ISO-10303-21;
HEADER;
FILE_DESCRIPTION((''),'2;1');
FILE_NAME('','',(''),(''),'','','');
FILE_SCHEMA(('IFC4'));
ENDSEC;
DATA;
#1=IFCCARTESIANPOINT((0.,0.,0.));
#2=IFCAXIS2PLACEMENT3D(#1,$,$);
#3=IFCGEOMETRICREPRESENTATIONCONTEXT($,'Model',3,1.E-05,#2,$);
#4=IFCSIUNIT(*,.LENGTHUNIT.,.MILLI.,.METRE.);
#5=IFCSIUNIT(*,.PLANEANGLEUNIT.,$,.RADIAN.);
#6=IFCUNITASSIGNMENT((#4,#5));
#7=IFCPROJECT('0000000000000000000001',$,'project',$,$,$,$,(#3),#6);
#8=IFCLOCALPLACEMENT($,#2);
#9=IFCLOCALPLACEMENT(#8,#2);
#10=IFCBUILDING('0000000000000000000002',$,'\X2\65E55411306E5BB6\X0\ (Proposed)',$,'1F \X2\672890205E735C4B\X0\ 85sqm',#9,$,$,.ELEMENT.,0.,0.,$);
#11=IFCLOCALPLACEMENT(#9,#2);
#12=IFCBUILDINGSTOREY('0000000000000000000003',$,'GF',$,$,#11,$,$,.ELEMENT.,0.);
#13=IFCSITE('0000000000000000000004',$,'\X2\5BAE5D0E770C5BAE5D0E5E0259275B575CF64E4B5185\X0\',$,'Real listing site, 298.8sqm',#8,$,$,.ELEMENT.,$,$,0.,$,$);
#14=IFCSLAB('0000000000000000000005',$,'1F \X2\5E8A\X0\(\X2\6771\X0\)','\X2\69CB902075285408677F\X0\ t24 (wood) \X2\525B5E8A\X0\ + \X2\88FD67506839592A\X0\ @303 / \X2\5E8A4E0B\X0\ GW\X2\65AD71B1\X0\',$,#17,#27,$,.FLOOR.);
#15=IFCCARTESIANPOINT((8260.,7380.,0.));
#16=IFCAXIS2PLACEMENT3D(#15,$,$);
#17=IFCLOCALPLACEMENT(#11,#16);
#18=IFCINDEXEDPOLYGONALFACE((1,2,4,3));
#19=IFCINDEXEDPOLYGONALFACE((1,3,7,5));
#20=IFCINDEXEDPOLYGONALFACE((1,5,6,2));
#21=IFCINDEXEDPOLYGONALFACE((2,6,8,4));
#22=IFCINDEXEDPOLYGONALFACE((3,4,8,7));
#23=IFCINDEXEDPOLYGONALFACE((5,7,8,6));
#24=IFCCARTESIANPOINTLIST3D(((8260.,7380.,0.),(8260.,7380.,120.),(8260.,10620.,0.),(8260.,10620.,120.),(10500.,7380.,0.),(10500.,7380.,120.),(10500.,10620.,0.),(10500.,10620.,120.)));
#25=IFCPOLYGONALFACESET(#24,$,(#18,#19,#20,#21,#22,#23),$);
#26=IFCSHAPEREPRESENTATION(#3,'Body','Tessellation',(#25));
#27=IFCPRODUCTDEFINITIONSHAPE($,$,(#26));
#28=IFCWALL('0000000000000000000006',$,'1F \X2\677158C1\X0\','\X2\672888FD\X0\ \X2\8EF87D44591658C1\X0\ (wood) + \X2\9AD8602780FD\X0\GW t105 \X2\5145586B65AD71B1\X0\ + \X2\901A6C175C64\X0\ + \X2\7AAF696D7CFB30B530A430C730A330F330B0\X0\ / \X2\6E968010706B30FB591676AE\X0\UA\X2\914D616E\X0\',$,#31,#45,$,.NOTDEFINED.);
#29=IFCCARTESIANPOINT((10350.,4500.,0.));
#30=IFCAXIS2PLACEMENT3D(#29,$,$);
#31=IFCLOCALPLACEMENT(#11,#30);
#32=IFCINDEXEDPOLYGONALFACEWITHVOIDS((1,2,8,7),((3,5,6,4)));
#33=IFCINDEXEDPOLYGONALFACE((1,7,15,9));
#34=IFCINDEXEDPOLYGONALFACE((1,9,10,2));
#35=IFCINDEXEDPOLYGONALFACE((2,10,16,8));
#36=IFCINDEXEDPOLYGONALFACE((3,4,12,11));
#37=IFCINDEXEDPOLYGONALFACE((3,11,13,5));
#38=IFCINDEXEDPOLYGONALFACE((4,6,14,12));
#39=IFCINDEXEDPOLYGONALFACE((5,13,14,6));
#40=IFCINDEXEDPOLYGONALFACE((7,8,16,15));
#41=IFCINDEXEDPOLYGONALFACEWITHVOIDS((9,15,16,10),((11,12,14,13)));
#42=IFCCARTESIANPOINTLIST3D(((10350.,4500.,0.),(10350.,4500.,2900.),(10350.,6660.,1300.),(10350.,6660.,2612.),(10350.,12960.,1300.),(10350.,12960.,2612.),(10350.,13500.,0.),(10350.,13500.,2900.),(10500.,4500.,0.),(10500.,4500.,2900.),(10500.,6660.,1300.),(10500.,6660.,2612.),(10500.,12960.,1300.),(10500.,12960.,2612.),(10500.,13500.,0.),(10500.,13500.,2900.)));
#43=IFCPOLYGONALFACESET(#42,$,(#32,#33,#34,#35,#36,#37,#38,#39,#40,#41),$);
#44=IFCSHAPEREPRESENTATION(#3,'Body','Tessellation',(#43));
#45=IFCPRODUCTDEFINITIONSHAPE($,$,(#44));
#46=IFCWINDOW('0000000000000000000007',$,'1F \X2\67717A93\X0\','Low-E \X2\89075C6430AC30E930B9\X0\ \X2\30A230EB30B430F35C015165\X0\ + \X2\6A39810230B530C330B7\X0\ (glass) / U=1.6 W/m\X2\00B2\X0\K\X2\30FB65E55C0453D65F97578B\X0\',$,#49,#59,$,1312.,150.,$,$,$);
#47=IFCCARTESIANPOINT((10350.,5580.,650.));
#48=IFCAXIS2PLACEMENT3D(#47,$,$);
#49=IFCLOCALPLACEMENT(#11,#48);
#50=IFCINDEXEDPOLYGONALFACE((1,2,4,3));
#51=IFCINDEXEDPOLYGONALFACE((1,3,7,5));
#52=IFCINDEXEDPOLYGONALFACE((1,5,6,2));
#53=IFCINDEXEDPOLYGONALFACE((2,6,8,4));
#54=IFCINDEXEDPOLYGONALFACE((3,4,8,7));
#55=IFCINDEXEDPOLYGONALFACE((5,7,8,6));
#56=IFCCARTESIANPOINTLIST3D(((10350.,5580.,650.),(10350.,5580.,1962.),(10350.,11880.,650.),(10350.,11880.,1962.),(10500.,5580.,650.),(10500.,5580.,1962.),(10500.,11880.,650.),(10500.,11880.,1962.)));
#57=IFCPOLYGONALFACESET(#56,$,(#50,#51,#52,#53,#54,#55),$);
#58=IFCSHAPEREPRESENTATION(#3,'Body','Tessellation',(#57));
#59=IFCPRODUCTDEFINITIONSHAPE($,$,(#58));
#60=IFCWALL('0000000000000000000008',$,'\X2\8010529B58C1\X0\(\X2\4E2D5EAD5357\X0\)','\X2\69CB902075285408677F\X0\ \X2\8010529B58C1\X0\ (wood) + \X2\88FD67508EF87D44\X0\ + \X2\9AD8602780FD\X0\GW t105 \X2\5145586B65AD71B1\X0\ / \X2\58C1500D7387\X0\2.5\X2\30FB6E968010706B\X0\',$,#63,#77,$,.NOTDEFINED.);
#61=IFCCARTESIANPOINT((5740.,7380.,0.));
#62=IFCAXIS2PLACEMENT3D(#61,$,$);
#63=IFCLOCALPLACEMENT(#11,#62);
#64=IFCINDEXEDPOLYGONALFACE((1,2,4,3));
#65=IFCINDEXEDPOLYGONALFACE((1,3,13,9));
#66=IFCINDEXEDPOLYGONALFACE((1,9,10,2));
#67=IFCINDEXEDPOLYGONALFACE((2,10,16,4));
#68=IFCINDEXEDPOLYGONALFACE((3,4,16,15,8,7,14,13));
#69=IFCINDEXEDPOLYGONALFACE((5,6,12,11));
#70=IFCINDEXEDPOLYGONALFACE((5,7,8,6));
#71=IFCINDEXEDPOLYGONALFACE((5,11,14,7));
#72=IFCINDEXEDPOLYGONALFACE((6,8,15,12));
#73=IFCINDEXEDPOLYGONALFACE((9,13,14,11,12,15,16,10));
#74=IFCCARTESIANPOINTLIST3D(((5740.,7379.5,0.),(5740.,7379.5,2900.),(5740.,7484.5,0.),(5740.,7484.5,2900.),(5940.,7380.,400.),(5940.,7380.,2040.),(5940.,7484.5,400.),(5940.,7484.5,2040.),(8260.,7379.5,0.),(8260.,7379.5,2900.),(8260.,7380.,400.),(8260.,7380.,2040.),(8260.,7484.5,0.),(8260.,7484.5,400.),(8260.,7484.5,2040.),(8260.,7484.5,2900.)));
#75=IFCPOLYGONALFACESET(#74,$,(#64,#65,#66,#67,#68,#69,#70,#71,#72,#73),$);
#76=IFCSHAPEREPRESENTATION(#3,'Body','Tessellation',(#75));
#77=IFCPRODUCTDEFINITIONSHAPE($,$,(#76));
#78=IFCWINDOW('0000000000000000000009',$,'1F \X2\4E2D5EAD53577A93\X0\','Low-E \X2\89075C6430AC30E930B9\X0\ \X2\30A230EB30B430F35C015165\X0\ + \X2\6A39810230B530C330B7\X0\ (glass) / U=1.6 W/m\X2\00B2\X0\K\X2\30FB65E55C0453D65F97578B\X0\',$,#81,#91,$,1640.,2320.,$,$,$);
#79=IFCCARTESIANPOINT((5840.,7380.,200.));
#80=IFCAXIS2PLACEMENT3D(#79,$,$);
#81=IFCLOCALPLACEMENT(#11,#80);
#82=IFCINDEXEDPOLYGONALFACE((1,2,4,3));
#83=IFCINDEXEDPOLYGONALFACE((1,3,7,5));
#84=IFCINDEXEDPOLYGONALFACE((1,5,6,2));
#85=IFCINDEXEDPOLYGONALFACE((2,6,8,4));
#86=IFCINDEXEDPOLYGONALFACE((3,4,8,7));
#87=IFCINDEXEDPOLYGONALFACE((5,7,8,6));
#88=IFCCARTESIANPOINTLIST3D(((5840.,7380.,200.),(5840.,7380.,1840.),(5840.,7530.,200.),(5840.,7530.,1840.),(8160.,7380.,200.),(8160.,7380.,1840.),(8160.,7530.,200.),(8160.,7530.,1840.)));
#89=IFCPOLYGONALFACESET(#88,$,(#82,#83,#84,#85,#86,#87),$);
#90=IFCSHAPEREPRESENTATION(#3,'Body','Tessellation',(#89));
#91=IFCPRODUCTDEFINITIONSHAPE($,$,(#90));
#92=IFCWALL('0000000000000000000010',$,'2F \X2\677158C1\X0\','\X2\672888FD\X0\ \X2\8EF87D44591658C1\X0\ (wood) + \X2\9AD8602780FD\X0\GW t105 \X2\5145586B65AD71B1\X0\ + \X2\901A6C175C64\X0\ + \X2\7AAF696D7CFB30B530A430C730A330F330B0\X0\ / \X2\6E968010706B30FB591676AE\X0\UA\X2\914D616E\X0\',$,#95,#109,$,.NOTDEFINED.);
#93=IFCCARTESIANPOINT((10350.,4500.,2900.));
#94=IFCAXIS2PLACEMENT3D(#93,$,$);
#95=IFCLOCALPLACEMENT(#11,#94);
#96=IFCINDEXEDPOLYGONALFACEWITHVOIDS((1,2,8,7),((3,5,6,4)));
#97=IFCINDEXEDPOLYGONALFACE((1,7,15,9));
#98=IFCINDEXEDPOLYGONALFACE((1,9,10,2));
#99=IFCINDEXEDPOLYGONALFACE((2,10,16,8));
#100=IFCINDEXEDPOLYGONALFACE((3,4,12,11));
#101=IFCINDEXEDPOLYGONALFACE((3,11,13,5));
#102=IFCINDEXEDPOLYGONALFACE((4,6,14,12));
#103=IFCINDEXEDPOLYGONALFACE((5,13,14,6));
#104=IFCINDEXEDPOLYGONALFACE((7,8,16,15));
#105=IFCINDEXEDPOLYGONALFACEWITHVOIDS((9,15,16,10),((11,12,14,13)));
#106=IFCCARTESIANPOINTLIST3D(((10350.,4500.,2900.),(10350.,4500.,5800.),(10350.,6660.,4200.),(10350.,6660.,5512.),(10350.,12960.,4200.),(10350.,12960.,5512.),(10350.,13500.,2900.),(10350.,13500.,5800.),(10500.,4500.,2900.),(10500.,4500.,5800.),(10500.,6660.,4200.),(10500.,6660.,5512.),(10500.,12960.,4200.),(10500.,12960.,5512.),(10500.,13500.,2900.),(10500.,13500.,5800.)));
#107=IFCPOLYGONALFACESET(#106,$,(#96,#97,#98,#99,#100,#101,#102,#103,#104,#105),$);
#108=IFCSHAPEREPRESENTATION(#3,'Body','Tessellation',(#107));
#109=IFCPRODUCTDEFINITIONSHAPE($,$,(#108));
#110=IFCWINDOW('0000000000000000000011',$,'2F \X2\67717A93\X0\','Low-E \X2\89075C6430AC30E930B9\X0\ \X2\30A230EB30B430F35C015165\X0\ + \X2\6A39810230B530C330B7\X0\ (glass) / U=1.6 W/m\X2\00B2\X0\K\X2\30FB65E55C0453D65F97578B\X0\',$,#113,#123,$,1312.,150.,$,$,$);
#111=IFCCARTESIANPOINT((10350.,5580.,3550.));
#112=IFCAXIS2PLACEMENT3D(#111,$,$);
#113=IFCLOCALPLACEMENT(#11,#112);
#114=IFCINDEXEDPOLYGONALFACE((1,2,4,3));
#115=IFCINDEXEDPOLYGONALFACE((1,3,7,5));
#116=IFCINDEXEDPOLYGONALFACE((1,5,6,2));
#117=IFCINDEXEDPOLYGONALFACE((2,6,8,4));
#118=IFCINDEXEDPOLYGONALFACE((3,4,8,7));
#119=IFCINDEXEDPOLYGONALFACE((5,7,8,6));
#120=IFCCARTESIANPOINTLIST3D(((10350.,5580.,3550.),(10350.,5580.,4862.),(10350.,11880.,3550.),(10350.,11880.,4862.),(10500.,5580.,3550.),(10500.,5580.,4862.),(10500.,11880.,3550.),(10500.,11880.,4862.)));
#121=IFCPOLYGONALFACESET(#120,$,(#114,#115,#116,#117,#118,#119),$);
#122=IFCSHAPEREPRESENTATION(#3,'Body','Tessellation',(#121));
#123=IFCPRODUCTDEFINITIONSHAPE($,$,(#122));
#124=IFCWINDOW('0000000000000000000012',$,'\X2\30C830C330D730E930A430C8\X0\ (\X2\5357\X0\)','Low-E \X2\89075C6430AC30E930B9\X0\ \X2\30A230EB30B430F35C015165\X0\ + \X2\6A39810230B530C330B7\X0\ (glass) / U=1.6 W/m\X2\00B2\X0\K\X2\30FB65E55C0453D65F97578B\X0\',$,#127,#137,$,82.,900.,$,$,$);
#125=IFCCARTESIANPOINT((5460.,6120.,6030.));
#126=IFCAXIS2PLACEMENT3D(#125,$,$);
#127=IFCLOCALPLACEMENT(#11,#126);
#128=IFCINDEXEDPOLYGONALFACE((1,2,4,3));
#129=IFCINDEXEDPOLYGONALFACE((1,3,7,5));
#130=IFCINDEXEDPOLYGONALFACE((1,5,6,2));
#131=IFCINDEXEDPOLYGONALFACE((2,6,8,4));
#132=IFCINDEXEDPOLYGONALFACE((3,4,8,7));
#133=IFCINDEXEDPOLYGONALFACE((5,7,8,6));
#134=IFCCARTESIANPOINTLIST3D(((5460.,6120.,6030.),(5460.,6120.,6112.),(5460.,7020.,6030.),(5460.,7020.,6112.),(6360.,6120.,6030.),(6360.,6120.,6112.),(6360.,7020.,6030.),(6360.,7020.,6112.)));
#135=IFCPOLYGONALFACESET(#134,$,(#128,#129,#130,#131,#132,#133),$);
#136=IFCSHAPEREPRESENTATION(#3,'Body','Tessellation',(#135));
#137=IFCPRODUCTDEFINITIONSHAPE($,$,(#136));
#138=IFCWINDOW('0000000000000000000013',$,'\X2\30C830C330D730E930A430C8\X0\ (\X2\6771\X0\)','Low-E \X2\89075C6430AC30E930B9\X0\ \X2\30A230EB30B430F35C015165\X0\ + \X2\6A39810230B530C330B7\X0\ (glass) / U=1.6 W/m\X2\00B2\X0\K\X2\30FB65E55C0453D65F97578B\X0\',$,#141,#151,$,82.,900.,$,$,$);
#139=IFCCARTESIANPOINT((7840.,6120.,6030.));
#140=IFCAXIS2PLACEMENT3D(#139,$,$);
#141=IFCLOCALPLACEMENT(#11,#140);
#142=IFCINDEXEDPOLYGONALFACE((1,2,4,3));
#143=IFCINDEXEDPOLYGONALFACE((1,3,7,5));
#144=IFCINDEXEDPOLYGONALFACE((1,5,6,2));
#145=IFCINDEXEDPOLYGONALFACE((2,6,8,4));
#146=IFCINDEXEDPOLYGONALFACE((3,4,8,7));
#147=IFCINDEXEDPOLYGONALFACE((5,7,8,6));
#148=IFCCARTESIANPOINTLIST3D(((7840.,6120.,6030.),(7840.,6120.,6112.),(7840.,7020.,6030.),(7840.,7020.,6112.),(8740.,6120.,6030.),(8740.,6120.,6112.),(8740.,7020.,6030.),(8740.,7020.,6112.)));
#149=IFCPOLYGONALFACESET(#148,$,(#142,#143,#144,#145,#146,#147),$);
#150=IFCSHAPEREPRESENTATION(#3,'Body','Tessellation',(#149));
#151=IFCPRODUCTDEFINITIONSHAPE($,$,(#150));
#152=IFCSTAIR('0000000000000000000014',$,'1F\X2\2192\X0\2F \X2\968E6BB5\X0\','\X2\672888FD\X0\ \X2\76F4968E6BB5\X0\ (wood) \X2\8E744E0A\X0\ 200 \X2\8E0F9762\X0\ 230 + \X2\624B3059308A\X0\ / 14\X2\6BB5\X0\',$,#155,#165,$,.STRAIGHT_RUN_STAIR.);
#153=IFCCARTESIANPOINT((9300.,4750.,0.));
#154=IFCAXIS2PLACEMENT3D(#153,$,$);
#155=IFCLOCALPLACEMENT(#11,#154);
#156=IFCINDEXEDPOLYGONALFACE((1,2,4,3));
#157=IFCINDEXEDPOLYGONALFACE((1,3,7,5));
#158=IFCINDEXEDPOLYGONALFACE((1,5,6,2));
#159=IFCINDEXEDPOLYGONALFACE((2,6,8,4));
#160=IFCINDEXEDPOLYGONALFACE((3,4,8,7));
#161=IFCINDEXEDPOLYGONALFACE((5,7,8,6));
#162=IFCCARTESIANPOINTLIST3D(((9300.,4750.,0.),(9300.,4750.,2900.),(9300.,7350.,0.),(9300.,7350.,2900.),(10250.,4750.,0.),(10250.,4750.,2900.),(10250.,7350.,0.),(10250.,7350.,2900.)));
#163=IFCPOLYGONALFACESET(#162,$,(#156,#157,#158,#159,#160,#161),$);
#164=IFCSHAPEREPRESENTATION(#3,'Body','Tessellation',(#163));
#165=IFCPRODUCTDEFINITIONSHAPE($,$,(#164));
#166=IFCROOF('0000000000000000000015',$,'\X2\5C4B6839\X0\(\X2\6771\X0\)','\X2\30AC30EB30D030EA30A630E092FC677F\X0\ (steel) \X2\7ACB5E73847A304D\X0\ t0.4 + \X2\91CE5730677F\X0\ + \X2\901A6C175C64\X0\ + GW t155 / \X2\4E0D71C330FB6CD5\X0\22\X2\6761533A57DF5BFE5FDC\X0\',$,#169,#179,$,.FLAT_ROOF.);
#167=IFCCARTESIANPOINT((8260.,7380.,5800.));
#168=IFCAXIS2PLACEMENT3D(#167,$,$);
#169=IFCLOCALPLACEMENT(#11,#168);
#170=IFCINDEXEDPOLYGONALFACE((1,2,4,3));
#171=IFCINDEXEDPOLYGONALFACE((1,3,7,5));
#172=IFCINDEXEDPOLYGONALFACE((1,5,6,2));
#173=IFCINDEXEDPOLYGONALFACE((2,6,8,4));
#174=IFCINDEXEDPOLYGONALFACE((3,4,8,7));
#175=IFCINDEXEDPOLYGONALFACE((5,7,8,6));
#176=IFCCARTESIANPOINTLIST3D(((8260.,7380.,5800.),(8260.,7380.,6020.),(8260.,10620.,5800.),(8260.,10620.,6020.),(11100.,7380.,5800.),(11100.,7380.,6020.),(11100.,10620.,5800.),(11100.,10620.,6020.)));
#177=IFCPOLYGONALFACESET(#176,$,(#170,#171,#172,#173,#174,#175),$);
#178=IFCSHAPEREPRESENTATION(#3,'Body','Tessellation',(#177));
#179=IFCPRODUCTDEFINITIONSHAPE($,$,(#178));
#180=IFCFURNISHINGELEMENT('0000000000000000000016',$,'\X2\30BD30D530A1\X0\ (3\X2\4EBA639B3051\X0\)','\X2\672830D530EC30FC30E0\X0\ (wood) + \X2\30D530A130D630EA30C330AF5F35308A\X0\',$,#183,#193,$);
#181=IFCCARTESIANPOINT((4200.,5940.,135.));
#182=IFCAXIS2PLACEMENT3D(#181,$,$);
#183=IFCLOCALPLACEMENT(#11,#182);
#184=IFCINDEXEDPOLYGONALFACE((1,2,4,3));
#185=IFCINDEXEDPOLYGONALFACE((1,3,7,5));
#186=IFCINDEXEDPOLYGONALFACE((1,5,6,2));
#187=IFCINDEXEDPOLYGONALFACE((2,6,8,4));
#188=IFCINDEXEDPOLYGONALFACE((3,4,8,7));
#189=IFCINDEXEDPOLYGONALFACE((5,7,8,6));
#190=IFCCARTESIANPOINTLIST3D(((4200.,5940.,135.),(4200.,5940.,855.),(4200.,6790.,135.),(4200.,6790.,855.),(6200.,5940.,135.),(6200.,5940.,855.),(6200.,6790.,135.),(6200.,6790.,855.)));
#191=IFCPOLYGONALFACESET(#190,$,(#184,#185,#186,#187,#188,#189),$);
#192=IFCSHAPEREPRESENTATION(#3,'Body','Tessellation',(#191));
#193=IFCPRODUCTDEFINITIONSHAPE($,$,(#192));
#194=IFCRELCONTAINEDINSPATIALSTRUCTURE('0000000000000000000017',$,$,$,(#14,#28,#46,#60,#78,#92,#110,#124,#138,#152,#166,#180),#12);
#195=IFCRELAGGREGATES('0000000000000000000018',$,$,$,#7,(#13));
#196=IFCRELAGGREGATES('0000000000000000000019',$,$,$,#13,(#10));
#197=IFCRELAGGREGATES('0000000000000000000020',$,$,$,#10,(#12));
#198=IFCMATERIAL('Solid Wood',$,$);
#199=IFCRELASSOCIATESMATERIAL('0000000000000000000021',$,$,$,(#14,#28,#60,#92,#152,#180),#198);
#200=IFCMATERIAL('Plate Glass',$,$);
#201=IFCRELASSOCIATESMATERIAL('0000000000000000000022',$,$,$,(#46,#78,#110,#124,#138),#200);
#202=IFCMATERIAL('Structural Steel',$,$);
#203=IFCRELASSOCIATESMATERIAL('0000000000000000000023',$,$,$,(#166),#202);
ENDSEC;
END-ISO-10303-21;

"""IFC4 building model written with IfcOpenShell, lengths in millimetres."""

from ifc_helpers import new_model, si_unit, frame, frame_2d, origin, place, context, project, spatial, rectangle, extrude, material, element, fill, save


model = new_model("IFC4")

# Units and contexts
model_context = context("Model", 3, precision=1e-05, world=origin())
ifc_project = project(units=[si_unit("LENGTHUNIT", "METRE", prefix="MILLI"), si_unit("PLANEANGLEUNIT", "RADIAN")], contexts=[model_context])

# Site, building, storey
site_placement = place(None, origin())
site = spatial("IfcSite", under=ifc_project, at=site_placement, Name="宮崎県宮崎市大字島之内", ObjectType="Real listing site, 298.8sqm", CompositionType="ELEMENT", RefElevation=0.0)
building_placement = place(site_placement, origin())
building = spatial("IfcBuilding", under=site, at=building_placement, Name="日向の家 (Proposed)", ObjectType="1F 木造平屋 85sqm", CompositionType="ELEMENT", ElevationOfRefHeight=0.0, ElevationOfTerrain=0.0)
storey_placement = place(building_placement, origin())
storey = spatial("IfcBuildingStorey", under=building, at=storey_placement, Name="GF", CompositionType="ELEMENT", Elevation=0.0)

# Slab
ifc_material_1 = material(Name="Solid Wood")
slab_placement = place(storey_placement, frame((8260.0, 7380.0, 0.0)))
element("IfcSlab", 1, at=slab_placement, inside=storey, material=ifc_material_1, Name="1F 床(東)", Description="構造用合板 t24 (wood) 剛床 + 製材根太 @303 / 床下 GW断熱", PredefinedType="FLOOR", context=model_context, shape_type="SweptSolid", body=[
    extrude(rectangle(XDim=2240.0, YDim=3240.0, at=frame_2d((1120.0, 1620.0))), frame((8260.0, 7380.0, 0.0)), (0.0, 0.0, 1.0), 120.0),
])

# Walls, openings, windows
wall_1_placement = place(storey_placement, frame((10350.0, 4500.0, 0.0)))
wall_1 = element("IfcWall", 2, at=wall_1_placement, inside=storey, material=ifc_material_1, Name="1F 東壁", Description="木製 軸組外壁 (wood) + 高性能GW t105 充填断熱 + 通気層 + 窯業系サイディング / 準耐火・外皮UA配慮", PredefinedType="NOTDEFINED", context=model_context, shape_type="SweptSolid", body=[
    extrude(rectangle(XDim=150.0, YDim=9000.0, at=frame_2d((75.0, 4500.0))), frame((10350.0, 4500.0, 0.0)), (0.0, 0.0, 1.0), 2900.0),
])
opening_1_placement = place(storey_placement, frame((10350.0, 5580.0, 650.0)))
opening_1 = element("IfcOpeningElement", 3, at=opening_1_placement, cuts=wall_1, PredefinedType="NOTDEFINED", context=model_context, shape_type="SweptSolid", body=[
    extrude(rectangle(XDim=150.0, YDim=6300.0, at=frame_2d((75.0, 3150.0))), frame((10350.0, 5580.0, 650.0)), (0.0, 0.0, 1.0), 1312.0),
])
ifc_material_2 = material(Name="Plate Glass")
window_1_placement = place(storey_placement, frame((10350.0, 5580.0, 650.0)))
window_1 = element("IfcWindow", 4, at=window_1_placement, inside=storey, material=ifc_material_2, Name="1F 東窓", Description="Low-E 複層ガラス アルゴン封入 + 樹脂サッシ (glass) / U=1.6 W/m²K・日射取得型", OverallHeight=1312.0, OverallWidth=150.0, context=model_context, shape_type="SweptSolid", body=[
    extrude(rectangle(XDim=150.0, YDim=6300.0, at=frame_2d((75.0, 3150.0))), frame((10350.0, 5580.0, 650.0)), (0.0, 0.0, 1.0), 1312.0),
])
fill(opening_1, window_1)
wall_2_placement = place(storey_placement, frame((5740.0, 7380.0, 0.0)))
wall_2 = element("IfcWall", 5, at=wall_2_placement, inside=storey, material=ifc_material_1, Name="耐力壁(中庭南)", Description="構造用合板 耐力壁 (wood) + 製材軸組 + 高性能GW t105 充填断熱 / 壁倍率2.5・準耐火", PredefinedType="NOTDEFINED", context=model_context, shape_type="SweptSolid", body=[
    extrude(rectangle(XDim=2520.0, YDim=105.0, at=frame_2d((1260.0, 52.0))), frame((5740.0, 7380.0, 0.0)), (0.0, 0.0, 1.0), 2900.0),
])
opening_2_placement = place(storey_placement, frame((5840.0, 7380.0, 200.0)))
opening_2 = element("IfcOpeningElement", 6, at=opening_2_placement, cuts=wall_2, PredefinedType="NOTDEFINED", context=model_context, shape_type="SweptSolid", body=[
    extrude(rectangle(XDim=2320.0, YDim=150.0, at=frame_2d((1160.0, 75.0))), frame((5840.0, 7380.0, 200.0)), (0.0, 0.0, 1.0), 1640.0),
])
window_2_placement = place(storey_placement, frame((5840.0, 7380.0, 200.0)))
window_2 = element("IfcWindow", 7, at=window_2_placement, inside=storey, material=ifc_material_2, Name="1F 中庭南窓", Description="Low-E 複層ガラス アルゴン封入 + 樹脂サッシ (glass) / U=1.6 W/m²K・日射取得型", OverallHeight=1640.0, OverallWidth=2320.0, context=model_context, shape_type="SweptSolid", body=[
    extrude(rectangle(XDim=2320.0, YDim=150.0, at=frame_2d((1160.0, 75.0))), frame((5840.0, 7380.0, 200.0)), (0.0, 0.0, 1.0), 1640.0),
])
fill(opening_2, window_2)

# Wall, opening, window
wall_3_placement = place(storey_placement, frame((10350.0, 4500.0, 2900.0)))
wall_3 = element("IfcWall", 8, at=wall_3_placement, inside=storey, material=ifc_material_1, Name="2F 東壁", Description="木製 軸組外壁 (wood) + 高性能GW t105 充填断熱 + 通気層 + 窯業系サイディング / 準耐火・外皮UA配慮", PredefinedType="NOTDEFINED", context=model_context, shape_type="SweptSolid", body=[
    extrude(rectangle(XDim=150.0, YDim=9000.0, at=frame_2d((75.0, 4500.0))), frame((10350.0, 4500.0, 2900.0)), (0.0, 0.0, 1.0), 2900.0),
])
opening_3_placement = place(storey_placement, frame((10350.0, 5580.0, 3550.0)))
opening_3 = element("IfcOpeningElement", 9, at=opening_3_placement, cuts=wall_3, PredefinedType="NOTDEFINED", context=model_context, shape_type="SweptSolid", body=[
    extrude(rectangle(XDim=150.0, YDim=6300.0, at=frame_2d((75.0, 3150.0))), frame((10350.0, 5580.0, 3550.0)), (0.0, 0.0, 1.0), 1312.0),
])
window_3_placement = place(storey_placement, frame((10350.0, 5580.0, 3550.0)))
window_3 = element("IfcWindow", 10, at=window_3_placement, inside=storey, material=ifc_material_2, Name="2F 東窓", Description="Low-E 複層ガラス アルゴン封入 + 樹脂サッシ (glass) / U=1.6 W/m²K・日射取得型", OverallHeight=1312.0, OverallWidth=150.0, context=model_context, shape_type="SweptSolid", body=[
    extrude(rectangle(XDim=150.0, YDim=6300.0, at=frame_2d((75.0, 3150.0))), frame((10350.0, 5580.0, 3550.0)), (0.0, 0.0, 1.0), 1312.0),
])
fill(opening_3, window_3)

# Windows
window_4_placement = place(storey_placement, frame((5460.0, 6120.0, 6030.0)))
element("IfcWindow", 11, at=window_4_placement, inside=storey, material=ifc_material_2, Name="トップライト (南)", Description="Low-E 複層ガラス アルゴン封入 + 樹脂サッシ (glass) / U=1.6 W/m²K・日射取得型", OverallHeight=82.0, OverallWidth=900.0, context=model_context, shape_type="SweptSolid", body=[
    extrude(rectangle(XDim=900.0, YDim=900.0, at=frame_2d((450.0, 450.0))), frame((5460.0, 6120.0, 6030.0)), (0.0, 0.0, 1.0), 82.0),
])
window_5_placement = place(storey_placement, frame((7840.0, 6120.0, 6030.0)))
element("IfcWindow", 12, at=window_5_placement, inside=storey, material=ifc_material_2, Name="トップライト (東)", Description="Low-E 複層ガラス アルゴン封入 + 樹脂サッシ (glass) / U=1.6 W/m²K・日射取得型", OverallHeight=82.0, OverallWidth=900.0, context=model_context, shape_type="SweptSolid", body=[
    extrude(rectangle(XDim=900.0, YDim=900.0, at=frame_2d((450.0, 450.0))), frame((7840.0, 6120.0, 6030.0)), (0.0, 0.0, 1.0), 82.0),
])

# Stair
stair_placement = place(storey_placement, frame((9300.0, 4750.0, 0.0)))
element("IfcStair", 13, at=stair_placement, inside=storey, material=ifc_material_1, Name="1F→2F 階段", Description="木製 直階段 (wood) 蹴上 200 踏面 230 + 手すり / 14段", PredefinedType="STRAIGHT_RUN_STAIR", context=model_context, shape_type="SweptSolid", body=[
    extrude(rectangle(XDim=950.0, YDim=2600.0, at=frame_2d((475.0, 1300.0))), frame((9300.0, 4750.0, 0.0)), (0.0, 0.0, 1.0), 2900.0),
])

# Roof
ifc_material_3 = material(Name="Structural Steel")
roof_placement = place(storey_placement, frame((8260.0, 7380.0, 5800.0)))
element("IfcRoof", 14, at=roof_placement, inside=storey, material=ifc_material_3, Name="屋根(東)", Description="ガルバリウム鋼板 (steel) 立平葺き t0.4 + 野地板 + 通気層 + GW t155 / 不燃・法22条区域対応", PredefinedType="FLAT_ROOF", context=model_context, shape_type="SweptSolid", body=[
    extrude(rectangle(XDim=2840.0, YDim=3240.0, at=frame_2d((1420.0, 1620.0))), frame((8260.0, 7380.0, 5800.0)), (0.0, 0.0, 1.0), 220.0),
])

# Furnishing element
furnishing_1_placement = place(storey_placement, frame((4200.0, 5940.0, 135.0)))
element("IfcFurnishingElement", 15, at=furnishing_1_placement, inside=storey, material=ifc_material_1, Name="ソファ (3人掛け)", Description="木フレーム (wood) + ファブリック張り", context=model_context, shape_type="SweptSolid", body=[
    extrude(rectangle(XDim=2000.0, YDim=850.0, at=frame_2d((1000.0, 425.0))), frame((4200.0, 5940.0, 135.0)), (0.0, 0.0, 1.0), 720.0),
])

save(model, "model.ifc")
